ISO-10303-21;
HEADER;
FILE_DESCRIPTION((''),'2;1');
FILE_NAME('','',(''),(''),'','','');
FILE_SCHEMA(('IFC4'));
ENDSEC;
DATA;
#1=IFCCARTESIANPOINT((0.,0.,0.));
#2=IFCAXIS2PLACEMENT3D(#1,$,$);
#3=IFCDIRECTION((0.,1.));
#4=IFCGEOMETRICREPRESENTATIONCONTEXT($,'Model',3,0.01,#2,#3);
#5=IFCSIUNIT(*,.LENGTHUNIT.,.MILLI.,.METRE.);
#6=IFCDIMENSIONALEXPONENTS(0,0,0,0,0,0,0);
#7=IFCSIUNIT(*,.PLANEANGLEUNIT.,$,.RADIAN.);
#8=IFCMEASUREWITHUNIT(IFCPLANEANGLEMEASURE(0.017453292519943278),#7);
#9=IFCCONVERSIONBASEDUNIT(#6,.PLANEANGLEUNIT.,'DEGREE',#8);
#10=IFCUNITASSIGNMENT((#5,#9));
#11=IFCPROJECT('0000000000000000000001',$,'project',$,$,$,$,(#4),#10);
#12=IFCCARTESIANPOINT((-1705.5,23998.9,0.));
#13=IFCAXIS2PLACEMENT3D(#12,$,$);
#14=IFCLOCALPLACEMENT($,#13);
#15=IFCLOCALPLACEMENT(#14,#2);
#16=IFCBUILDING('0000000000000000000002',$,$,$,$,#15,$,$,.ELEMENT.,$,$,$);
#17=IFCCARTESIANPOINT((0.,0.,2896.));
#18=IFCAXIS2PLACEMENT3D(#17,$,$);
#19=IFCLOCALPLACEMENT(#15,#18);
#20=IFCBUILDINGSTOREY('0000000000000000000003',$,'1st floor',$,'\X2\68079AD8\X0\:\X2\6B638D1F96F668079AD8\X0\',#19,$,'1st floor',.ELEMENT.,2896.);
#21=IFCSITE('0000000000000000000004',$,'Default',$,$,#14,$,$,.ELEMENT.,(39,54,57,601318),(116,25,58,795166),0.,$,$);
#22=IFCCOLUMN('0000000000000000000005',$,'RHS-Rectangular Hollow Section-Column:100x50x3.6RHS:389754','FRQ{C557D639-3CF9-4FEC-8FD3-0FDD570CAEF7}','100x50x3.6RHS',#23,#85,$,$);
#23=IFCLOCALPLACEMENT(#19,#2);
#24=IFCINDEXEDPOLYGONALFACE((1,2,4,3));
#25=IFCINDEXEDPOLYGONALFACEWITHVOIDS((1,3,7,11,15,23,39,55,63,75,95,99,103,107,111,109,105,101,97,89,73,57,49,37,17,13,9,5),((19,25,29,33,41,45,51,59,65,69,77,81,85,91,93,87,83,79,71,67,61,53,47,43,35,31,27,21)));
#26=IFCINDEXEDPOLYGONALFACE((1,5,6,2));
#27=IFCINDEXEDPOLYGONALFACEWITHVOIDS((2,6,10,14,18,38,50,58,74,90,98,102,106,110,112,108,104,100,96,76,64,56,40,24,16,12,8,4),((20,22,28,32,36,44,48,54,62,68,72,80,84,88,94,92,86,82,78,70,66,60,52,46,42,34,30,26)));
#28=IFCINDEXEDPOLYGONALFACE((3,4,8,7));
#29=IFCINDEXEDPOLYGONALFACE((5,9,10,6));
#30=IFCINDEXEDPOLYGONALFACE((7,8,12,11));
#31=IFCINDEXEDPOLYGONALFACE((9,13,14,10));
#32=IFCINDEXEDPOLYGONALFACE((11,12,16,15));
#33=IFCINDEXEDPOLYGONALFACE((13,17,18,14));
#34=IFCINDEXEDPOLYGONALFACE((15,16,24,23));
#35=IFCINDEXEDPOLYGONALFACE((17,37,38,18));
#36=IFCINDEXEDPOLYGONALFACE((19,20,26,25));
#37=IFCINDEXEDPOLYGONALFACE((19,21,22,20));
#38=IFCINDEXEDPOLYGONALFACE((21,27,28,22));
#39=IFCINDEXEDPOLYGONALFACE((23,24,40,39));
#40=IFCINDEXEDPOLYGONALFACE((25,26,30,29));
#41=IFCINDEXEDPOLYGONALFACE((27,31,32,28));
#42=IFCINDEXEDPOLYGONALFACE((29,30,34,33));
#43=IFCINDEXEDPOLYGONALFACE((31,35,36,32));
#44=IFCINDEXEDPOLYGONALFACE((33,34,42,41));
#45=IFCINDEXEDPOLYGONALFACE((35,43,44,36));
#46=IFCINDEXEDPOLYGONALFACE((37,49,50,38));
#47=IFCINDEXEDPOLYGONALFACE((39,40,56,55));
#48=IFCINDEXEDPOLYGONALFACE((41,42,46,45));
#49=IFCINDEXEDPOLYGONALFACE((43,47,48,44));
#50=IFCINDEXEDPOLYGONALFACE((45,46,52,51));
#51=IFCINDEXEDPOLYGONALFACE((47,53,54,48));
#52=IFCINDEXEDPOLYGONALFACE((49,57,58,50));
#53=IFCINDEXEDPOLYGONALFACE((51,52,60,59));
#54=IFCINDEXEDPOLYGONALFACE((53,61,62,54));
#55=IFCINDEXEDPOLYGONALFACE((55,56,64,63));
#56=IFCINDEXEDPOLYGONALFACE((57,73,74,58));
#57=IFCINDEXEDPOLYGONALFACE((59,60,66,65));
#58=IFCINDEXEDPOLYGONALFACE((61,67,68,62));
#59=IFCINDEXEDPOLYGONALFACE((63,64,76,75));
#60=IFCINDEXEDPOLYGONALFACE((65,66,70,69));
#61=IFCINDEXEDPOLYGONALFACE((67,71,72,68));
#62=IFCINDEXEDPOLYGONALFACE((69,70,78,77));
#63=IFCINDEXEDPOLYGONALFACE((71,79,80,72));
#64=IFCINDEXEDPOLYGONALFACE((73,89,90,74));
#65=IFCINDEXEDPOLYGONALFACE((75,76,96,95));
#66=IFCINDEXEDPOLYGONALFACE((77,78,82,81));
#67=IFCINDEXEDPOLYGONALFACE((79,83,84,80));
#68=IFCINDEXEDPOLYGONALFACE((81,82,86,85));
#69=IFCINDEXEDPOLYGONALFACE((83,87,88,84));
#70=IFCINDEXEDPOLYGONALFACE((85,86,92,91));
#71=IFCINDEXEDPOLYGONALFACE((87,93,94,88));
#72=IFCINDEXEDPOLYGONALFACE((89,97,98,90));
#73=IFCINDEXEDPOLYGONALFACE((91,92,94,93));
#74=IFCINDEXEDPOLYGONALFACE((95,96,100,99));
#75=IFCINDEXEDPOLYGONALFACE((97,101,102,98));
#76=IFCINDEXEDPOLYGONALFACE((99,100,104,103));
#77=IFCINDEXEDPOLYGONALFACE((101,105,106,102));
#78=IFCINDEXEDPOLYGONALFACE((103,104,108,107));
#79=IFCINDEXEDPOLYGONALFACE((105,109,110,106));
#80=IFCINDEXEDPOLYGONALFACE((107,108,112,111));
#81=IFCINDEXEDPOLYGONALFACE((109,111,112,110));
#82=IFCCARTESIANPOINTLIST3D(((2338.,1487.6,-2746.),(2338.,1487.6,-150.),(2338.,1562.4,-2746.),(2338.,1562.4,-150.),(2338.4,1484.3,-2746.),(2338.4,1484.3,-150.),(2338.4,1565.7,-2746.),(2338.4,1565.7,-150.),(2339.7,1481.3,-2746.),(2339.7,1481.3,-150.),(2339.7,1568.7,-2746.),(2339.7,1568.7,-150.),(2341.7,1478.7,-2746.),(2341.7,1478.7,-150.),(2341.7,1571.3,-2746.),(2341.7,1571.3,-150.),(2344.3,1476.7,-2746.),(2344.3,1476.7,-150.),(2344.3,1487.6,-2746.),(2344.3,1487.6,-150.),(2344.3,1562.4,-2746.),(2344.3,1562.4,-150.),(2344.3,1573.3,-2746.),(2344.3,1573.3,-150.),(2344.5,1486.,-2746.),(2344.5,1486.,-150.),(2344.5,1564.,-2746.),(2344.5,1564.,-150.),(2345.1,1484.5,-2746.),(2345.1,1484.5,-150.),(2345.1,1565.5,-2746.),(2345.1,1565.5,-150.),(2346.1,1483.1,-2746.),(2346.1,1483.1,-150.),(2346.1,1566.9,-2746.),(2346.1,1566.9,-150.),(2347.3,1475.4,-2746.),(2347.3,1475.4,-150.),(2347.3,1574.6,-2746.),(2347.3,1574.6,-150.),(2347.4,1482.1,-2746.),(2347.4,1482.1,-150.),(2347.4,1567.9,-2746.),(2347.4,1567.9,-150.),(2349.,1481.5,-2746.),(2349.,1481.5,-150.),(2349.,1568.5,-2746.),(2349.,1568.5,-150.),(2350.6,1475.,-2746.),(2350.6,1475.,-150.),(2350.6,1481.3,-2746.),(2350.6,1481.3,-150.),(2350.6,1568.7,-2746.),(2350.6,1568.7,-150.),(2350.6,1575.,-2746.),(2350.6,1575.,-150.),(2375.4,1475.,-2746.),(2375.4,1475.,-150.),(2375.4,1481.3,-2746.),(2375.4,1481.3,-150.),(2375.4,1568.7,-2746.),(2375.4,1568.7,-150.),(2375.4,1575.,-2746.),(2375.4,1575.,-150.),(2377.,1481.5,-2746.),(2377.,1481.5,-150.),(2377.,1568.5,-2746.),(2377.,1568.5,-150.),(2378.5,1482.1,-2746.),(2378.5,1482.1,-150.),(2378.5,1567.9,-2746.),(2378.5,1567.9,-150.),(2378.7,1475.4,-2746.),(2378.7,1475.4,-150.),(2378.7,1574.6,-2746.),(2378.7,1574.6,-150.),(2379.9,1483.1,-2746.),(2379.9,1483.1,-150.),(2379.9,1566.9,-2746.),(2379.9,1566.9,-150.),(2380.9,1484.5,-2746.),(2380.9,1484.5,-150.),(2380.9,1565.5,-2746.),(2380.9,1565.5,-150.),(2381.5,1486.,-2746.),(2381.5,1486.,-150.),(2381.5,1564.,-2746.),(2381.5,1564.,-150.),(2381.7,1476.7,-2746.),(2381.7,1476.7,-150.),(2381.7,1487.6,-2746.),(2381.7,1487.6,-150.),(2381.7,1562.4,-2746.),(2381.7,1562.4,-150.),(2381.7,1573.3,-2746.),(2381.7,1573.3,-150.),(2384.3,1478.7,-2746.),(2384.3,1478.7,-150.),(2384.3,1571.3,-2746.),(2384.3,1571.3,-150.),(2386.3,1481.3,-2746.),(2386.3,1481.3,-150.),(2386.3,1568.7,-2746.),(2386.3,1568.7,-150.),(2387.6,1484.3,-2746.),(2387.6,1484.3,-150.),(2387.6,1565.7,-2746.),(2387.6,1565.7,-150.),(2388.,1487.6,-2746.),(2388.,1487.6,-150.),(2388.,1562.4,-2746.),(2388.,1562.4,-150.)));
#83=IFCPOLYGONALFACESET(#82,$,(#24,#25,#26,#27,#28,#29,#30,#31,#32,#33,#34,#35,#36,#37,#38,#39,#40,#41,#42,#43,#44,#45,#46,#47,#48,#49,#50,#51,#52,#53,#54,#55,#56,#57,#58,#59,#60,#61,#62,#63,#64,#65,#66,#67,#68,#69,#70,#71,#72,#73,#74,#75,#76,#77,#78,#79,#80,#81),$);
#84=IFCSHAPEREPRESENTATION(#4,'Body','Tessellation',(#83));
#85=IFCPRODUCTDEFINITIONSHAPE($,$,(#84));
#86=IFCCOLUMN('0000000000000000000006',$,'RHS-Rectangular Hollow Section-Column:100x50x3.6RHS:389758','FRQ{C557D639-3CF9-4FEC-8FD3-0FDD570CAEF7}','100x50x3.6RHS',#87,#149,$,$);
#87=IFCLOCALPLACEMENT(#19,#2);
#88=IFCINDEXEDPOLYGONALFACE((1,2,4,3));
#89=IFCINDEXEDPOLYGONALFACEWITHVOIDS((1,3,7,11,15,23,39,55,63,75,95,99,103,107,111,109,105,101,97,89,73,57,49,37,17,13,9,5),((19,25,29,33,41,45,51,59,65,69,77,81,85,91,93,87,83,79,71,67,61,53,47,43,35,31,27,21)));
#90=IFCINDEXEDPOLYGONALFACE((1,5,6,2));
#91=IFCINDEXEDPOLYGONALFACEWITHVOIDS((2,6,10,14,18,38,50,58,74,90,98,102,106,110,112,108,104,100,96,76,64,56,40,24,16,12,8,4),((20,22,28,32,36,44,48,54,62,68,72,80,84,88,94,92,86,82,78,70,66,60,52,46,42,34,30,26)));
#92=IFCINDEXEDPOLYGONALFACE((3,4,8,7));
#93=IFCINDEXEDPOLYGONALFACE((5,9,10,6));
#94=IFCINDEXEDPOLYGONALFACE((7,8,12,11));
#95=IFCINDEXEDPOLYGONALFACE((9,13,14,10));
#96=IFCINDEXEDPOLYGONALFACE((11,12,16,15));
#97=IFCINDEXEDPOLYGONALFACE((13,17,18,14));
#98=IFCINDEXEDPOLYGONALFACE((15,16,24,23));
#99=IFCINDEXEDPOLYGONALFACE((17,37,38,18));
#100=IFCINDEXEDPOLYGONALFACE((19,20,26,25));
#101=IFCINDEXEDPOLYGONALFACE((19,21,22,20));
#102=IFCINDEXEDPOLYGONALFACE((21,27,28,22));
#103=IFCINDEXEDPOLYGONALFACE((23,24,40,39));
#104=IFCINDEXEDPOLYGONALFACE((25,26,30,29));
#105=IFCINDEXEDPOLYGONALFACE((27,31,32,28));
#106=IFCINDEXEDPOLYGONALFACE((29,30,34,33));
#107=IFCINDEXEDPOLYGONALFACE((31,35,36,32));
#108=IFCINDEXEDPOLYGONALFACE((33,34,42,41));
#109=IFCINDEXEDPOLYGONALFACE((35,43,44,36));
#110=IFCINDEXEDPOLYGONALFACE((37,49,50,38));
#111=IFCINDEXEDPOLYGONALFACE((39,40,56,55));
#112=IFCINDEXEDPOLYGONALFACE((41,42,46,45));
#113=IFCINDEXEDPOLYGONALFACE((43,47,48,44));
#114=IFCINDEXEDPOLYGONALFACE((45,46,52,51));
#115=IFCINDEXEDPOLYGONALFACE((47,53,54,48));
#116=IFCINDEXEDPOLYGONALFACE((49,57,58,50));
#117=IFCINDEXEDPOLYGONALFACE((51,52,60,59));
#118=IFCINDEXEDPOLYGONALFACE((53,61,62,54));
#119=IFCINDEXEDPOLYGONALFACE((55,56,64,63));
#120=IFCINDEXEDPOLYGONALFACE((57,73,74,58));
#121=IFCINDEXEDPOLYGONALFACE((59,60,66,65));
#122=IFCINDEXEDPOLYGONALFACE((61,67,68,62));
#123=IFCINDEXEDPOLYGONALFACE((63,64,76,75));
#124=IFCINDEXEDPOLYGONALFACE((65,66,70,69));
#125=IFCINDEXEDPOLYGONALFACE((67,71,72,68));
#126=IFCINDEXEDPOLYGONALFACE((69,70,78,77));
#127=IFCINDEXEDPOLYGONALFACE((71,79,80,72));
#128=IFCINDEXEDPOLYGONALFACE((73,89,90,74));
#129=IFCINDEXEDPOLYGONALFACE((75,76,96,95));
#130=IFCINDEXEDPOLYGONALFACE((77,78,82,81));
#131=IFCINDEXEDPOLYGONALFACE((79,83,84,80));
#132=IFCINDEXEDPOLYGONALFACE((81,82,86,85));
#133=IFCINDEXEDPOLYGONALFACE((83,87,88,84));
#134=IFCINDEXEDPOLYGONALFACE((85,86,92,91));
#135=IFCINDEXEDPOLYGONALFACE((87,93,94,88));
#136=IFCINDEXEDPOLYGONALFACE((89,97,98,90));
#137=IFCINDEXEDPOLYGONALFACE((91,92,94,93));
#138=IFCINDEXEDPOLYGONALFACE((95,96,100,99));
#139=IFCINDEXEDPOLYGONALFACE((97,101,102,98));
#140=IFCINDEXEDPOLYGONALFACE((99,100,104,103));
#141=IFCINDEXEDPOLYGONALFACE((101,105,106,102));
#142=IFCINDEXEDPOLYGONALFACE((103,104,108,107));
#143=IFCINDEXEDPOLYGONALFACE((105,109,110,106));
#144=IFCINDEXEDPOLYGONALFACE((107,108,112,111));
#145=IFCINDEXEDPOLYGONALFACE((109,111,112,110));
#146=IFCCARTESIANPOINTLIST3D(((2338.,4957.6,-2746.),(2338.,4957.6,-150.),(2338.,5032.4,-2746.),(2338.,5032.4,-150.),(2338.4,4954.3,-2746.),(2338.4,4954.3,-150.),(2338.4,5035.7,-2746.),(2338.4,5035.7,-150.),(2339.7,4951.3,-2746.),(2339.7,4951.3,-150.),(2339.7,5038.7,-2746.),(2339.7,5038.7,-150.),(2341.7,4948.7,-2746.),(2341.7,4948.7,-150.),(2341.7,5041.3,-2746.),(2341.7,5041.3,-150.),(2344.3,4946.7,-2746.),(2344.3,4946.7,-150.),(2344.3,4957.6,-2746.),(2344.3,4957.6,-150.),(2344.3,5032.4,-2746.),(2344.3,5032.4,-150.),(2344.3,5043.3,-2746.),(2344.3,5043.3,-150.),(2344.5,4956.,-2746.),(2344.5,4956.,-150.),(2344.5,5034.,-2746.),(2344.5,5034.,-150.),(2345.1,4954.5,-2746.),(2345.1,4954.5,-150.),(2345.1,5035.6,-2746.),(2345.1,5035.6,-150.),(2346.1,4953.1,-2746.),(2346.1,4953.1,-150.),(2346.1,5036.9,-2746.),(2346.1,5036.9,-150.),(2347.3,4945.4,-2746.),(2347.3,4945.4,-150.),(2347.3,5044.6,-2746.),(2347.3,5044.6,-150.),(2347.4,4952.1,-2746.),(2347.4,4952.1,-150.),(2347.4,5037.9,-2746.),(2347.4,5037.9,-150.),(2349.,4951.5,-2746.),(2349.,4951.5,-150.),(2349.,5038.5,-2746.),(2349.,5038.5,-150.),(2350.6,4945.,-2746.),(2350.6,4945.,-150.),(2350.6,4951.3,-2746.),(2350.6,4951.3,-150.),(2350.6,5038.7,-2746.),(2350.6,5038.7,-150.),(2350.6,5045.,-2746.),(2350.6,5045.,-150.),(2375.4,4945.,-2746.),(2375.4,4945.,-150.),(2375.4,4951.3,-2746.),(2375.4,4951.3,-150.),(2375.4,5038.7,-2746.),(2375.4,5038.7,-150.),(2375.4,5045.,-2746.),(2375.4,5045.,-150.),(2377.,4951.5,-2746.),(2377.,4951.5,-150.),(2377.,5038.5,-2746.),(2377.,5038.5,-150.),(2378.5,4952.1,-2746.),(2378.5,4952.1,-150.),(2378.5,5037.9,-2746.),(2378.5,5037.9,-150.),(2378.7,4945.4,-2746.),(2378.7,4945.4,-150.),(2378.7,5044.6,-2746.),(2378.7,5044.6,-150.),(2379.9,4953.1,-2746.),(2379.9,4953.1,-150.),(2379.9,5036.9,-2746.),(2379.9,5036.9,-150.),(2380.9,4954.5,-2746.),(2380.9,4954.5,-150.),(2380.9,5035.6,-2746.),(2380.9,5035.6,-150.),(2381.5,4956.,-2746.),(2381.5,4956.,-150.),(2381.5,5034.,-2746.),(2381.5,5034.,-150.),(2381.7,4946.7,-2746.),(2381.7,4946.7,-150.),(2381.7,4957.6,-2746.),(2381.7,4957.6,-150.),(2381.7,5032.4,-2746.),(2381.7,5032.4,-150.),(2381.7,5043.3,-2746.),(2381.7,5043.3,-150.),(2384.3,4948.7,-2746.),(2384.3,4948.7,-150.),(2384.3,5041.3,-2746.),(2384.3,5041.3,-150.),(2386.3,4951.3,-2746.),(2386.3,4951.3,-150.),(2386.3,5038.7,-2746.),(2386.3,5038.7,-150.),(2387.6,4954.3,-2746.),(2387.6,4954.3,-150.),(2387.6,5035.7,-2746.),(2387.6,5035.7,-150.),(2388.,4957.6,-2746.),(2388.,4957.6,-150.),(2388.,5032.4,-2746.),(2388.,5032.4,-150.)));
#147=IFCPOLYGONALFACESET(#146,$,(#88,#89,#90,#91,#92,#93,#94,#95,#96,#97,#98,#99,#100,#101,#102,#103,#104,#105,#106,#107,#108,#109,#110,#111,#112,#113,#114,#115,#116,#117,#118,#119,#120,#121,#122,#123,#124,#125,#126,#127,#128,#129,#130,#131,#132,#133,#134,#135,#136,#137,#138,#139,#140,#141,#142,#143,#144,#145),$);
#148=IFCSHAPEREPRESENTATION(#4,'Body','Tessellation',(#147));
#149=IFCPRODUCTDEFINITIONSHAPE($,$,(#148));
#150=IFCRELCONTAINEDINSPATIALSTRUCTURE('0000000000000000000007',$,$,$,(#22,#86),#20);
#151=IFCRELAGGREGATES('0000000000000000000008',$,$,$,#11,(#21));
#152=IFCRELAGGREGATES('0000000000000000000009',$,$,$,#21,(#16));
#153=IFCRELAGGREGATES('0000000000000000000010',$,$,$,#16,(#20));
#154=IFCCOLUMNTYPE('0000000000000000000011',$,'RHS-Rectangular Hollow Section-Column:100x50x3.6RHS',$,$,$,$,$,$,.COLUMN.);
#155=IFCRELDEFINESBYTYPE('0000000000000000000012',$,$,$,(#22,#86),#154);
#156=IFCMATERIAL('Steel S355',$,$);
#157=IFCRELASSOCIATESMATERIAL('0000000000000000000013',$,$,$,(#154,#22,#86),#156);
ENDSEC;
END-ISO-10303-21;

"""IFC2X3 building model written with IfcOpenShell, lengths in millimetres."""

from ifc_helpers import new_model, entity, si_unit, converted_unit, direction, frame, origin, origin_2d, place, context, project, spatial, hollow_rectangle, extrude, clip, halfspace, material, type_object, element, save


model = new_model("IFC2X3")

# Units and contexts
model_context = context("Model", 3, precision=0.01, world=origin(), true_north=direction((0.0, 1.0)))
ifc_project = project(units=[si_unit("LENGTHUNIT", "METRE", prefix="MILLI"), converted_unit("PLANEANGLEUNIT", "DEGREE", entity("IfcPlaneAngleMeasure", 0.017453292519943278), si_unit("PLANEANGLEUNIT", "RADIAN"), dimensions=[0, 0, 0, 0, 0, 0, 0])], contexts=[model_context])

# Site, building, storey
site_placement = place(None, frame((-1705.5, 23998.9, 0.0)))
site = spatial("IfcSite", under=ifc_project, at=site_placement, Name="Default", CompositionType="ELEMENT", RefLatitude=(39, 54, 57, 601318), RefLongitude=(116, 25, 58, 795166), RefElevation=0.0)
building_placement = place(site_placement, origin())
building = spatial("IfcBuilding", under=site, at=building_placement, CompositionType="ELEMENT")
storey_placement = place(building_placement, frame((0.0, 0.0, 2896.0)))
storey = spatial("IfcBuildingStorey", under=building, at=storey_placement, Name="1st floor", ObjectType="标高:正负零标高", LongName="1st floor", CompositionType="ELEMENT", Elevation=2896.0)

# Columns
ifc_material_1 = material(Name="Steel S355")
column_type_1 = type_object("IfcColumnType", Name="RHS-Rectangular Hollow Section-Column:100x50x3.6RHS", PredefinedType="COLUMN", material=ifc_material_1)
column_1_placement = place(storey_placement, frame((2363.0, 1525.0, -150.0), z_axis=(0.0, 0.0, 1.0), x_axis=(-1.0, 0.0, 0.0)))
element("IfcColumn", 1, at=column_1_placement, inside=storey, type_object=column_type_1, material=ifc_material_1, Name="RHS-Rectangular Hollow Section-Column:100x50x3.6RHS:389754", Description="FRQ{C557D639-3CF9-4FEC-8FD3-0FDD570CAEF7}", ObjectType="100x50x3.6RHS", context=model_context, shape_type="Clipping", body=[
    clip(extrude(hollow_rectangle(XDim=50.0, YDim=100.0, WallThickness=6.3, InnerFilletRadius=6.3, OuterFilletRadius=12.6, at=origin_2d()), origin(), (0.0, 0.0, -1.0), 2651.9), halfspace(frame((2363.0, 1525.0, -2596.0), z_axis=(0.0, 0.0, 1.0), x_axis=(-1.0, 0.0, 0.0)), True)),
])
column_2_placement = place(storey_placement, frame((2363.0, 4995.0, -150.0), z_axis=(0.0, 0.0, 1.0), x_axis=(-1.0, 0.0, 0.0)))
element("IfcColumn", 2, at=column_2_placement, inside=storey, type_object=column_type_1, material=ifc_material_1, Name="RHS-Rectangular Hollow Section-Column:100x50x3.6RHS:389758", Description="FRQ{C557D639-3CF9-4FEC-8FD3-0FDD570CAEF7}", ObjectType="100x50x3.6RHS", context=model_context, shape_type="Clipping", body=[
    clip(extrude(hollow_rectangle(XDim=50.0, YDim=100.0, WallThickness=6.3, InnerFilletRadius=6.3, OuterFilletRadius=12.6, at=origin_2d()), origin(), (0.0, 0.0, -1.0), 2651.9), halfspace(frame((2363.0, 4995.0, -2596.0), z_axis=(0.0, 0.0, 1.0), x_axis=(-1.0, 0.0, 0.0)), True)),
])

save(model, "model.ifc")
